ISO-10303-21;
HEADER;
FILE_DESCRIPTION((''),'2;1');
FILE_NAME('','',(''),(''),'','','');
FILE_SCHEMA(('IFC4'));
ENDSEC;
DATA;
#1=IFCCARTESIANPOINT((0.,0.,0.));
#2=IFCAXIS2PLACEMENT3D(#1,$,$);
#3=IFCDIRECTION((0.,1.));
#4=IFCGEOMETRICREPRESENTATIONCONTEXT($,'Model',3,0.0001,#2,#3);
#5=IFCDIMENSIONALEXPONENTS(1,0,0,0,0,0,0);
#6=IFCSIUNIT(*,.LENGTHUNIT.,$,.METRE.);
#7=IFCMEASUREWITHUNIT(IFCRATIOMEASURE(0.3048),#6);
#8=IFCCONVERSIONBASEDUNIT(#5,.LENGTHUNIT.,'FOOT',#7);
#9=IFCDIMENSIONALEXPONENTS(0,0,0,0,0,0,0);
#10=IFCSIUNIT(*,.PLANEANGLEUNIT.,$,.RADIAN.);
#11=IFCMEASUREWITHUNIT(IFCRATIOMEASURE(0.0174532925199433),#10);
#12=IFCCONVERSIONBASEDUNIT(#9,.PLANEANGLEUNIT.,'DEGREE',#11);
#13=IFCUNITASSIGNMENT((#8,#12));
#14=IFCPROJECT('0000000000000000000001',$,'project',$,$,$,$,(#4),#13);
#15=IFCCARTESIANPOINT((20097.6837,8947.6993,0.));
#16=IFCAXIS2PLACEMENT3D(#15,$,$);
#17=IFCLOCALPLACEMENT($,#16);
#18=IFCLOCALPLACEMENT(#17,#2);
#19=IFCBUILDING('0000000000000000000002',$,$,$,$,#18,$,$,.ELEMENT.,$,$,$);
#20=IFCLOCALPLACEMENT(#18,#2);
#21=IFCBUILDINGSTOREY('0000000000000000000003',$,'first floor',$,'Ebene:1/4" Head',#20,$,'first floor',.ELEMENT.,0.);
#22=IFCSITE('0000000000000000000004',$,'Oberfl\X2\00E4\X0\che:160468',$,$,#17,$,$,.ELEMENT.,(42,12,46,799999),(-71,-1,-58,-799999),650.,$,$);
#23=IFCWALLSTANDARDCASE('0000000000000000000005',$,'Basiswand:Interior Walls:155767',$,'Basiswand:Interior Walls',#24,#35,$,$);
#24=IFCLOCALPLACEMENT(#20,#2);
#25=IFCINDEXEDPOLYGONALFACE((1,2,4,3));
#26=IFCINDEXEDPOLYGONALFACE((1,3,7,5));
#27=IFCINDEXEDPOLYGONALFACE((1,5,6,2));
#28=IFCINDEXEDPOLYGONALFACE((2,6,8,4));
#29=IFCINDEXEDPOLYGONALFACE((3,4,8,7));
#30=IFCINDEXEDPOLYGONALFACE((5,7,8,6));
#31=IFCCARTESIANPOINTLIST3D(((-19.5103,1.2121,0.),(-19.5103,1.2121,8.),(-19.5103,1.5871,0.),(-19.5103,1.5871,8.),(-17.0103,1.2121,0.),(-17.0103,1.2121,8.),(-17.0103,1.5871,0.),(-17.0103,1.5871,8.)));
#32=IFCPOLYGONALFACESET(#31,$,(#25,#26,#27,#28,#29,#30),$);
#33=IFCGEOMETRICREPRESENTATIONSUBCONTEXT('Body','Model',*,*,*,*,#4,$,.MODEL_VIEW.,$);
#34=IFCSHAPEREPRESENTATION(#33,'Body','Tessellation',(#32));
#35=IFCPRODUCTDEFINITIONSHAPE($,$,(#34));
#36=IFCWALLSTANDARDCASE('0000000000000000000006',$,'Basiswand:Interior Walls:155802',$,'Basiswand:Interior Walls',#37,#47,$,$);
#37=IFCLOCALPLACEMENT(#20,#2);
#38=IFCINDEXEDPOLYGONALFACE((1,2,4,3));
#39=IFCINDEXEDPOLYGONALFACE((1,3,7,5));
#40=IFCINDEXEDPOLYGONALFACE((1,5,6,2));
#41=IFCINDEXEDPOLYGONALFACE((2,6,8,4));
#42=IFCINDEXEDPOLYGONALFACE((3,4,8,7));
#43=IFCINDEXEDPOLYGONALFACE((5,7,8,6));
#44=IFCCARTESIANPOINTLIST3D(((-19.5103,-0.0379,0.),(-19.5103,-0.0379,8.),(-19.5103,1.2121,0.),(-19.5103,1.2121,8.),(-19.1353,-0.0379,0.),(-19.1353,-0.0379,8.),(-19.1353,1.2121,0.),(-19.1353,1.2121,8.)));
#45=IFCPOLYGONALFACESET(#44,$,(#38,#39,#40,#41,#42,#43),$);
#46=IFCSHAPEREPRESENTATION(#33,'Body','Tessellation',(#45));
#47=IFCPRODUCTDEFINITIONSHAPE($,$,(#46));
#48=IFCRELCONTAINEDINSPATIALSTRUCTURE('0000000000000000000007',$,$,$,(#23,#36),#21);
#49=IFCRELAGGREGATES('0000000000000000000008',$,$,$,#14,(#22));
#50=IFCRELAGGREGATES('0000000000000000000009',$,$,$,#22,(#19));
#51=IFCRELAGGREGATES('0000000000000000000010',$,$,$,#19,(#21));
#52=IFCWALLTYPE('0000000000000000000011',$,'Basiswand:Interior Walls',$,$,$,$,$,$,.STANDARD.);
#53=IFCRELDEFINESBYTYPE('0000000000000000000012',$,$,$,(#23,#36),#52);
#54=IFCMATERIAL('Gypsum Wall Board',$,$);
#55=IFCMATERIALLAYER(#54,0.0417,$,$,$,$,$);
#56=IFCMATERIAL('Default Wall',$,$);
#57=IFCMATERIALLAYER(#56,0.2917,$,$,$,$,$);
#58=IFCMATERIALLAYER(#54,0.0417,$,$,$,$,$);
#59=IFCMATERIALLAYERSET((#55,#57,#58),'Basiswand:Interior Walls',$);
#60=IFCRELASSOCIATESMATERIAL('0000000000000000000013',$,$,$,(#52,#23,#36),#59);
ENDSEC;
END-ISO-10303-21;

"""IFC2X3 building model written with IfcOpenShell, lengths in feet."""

from ifc_helpers import new_model, entity, si_unit, converted_unit, direction, frame, frame_2d, origin, place, context, subcontext, project, spatial, rectangle, extrude, material, layer, layer_set, layer_usage, type_object, element, save


model = new_model("IFC2X3")

# Units and contexts
model_context = context("Model", 3, precision=0.0001, world=origin(), true_north=direction((0.0, 1.0)))
body_context = subcontext(model_context, "Body", "Model", "MODEL_VIEW")
ifc_project = project(units=[converted_unit("LENGTHUNIT", "FOOT", entity("IfcRatioMeasure", 0.3048), si_unit("LENGTHUNIT", "METRE"), dimensions=[1, 0, 0, 0, 0, 0, 0]), converted_unit("PLANEANGLEUNIT", "DEGREE", entity("IfcRatioMeasure", 0.0174532925199433), si_unit("PLANEANGLEUNIT", "RADIAN"), dimensions=[0, 0, 0, 0, 0, 0, 0])], contexts=[model_context])

# Site, building, storey
site_placement = place(None, frame((20097.6837, 8947.6993, 0.0)))
site = spatial("IfcSite", under=ifc_project, at=site_placement, Name="Oberfläche:160468", CompositionType="ELEMENT", RefLatitude=(42, 12, 46, 799999), RefLongitude=(-71, -1, -58, -799999), RefElevation=650.0)
building_placement = place(site_placement, origin())
building = spatial("IfcBuilding", under=site, at=building_placement, CompositionType="ELEMENT")
storey_placement = place(building_placement, origin())
storey = spatial("IfcBuildingStorey", under=building, at=storey_placement, Name="first floor", ObjectType="Ebene:1/4\" Head", LongName="first floor", CompositionType="ELEMENT", Elevation=0.0)

# Shared definitions
ifc_material_1 = material(Name="Gypsum Wall Board")

# Shared definitions
ifc_layer_1 = layer(ifc_material_1, 0.0417)
ifc_material_2 = material(Name="Default Wall")
ifc_layer_2 = layer(ifc_material_2, 0.2917)
ifc_layer_3 = layer(ifc_material_1, 0.0417)
ifc_layer_set_1 = layer_set([ifc_layer_1, ifc_layer_2, ifc_layer_3], Name="Basiswand:Interior Walls")
wall_type_1 = type_object("IfcWallType", Name="Basiswand:Interior Walls", PredefinedType="STANDARD", material=ifc_layer_set_1)

# Walls
ifc_layer_usage_1 = layer_usage(ifc_layer_set_1, "AXIS2", "NEGATIVE", 0.1875)
wall_1_placement = place(storey_placement, frame((-17.0103, 1.3996, 0.0), z_axis=(0.0, 0.0, 1.0), x_axis=(-1.0, 0.0, 0.0)))
element("IfcWallStandardCase", 1, at=wall_1_placement, inside=storey, type_object=wall_type_1, material=ifc_layer_usage_1, Name="Basiswand:Interior Walls:155767", ObjectType="Basiswand:Interior Walls", context=body_context, shape_type="SweptSolid", body=[
    extrude(rectangle(XDim=2.5, YDim=0.375, at=frame_2d((1.25, 0.0), x_axis=(-1.0, 0.0))), origin(), (0.0, 0.0, 1.0), 8.0),
])
ifc_layer_usage_2 = layer_usage(ifc_layer_set_1, "AXIS2", "NEGATIVE", 0.1875)
wall_2_placement = place(storey_placement, frame((-19.3228, 1.2121, 0.0), z_axis=(0.0, 0.0, 1.0), x_axis=(0.0, -1.0, 0.0)))
element("IfcWallStandardCase", 2, at=wall_2_placement, inside=storey, type_object=wall_type_1, material=ifc_layer_usage_2, Name="Basiswand:Interior Walls:155802", ObjectType="Basiswand:Interior Walls", context=body_context, shape_type="SweptSolid", body=[
    extrude(rectangle(XDim=1.25, YDim=0.375, at=frame_2d((0.625, 0.0), x_axis=(-1.0, 0.0))), origin(), (0.0, 0.0, 1.0), 8.0),
])

save(model, "model.ifc")
